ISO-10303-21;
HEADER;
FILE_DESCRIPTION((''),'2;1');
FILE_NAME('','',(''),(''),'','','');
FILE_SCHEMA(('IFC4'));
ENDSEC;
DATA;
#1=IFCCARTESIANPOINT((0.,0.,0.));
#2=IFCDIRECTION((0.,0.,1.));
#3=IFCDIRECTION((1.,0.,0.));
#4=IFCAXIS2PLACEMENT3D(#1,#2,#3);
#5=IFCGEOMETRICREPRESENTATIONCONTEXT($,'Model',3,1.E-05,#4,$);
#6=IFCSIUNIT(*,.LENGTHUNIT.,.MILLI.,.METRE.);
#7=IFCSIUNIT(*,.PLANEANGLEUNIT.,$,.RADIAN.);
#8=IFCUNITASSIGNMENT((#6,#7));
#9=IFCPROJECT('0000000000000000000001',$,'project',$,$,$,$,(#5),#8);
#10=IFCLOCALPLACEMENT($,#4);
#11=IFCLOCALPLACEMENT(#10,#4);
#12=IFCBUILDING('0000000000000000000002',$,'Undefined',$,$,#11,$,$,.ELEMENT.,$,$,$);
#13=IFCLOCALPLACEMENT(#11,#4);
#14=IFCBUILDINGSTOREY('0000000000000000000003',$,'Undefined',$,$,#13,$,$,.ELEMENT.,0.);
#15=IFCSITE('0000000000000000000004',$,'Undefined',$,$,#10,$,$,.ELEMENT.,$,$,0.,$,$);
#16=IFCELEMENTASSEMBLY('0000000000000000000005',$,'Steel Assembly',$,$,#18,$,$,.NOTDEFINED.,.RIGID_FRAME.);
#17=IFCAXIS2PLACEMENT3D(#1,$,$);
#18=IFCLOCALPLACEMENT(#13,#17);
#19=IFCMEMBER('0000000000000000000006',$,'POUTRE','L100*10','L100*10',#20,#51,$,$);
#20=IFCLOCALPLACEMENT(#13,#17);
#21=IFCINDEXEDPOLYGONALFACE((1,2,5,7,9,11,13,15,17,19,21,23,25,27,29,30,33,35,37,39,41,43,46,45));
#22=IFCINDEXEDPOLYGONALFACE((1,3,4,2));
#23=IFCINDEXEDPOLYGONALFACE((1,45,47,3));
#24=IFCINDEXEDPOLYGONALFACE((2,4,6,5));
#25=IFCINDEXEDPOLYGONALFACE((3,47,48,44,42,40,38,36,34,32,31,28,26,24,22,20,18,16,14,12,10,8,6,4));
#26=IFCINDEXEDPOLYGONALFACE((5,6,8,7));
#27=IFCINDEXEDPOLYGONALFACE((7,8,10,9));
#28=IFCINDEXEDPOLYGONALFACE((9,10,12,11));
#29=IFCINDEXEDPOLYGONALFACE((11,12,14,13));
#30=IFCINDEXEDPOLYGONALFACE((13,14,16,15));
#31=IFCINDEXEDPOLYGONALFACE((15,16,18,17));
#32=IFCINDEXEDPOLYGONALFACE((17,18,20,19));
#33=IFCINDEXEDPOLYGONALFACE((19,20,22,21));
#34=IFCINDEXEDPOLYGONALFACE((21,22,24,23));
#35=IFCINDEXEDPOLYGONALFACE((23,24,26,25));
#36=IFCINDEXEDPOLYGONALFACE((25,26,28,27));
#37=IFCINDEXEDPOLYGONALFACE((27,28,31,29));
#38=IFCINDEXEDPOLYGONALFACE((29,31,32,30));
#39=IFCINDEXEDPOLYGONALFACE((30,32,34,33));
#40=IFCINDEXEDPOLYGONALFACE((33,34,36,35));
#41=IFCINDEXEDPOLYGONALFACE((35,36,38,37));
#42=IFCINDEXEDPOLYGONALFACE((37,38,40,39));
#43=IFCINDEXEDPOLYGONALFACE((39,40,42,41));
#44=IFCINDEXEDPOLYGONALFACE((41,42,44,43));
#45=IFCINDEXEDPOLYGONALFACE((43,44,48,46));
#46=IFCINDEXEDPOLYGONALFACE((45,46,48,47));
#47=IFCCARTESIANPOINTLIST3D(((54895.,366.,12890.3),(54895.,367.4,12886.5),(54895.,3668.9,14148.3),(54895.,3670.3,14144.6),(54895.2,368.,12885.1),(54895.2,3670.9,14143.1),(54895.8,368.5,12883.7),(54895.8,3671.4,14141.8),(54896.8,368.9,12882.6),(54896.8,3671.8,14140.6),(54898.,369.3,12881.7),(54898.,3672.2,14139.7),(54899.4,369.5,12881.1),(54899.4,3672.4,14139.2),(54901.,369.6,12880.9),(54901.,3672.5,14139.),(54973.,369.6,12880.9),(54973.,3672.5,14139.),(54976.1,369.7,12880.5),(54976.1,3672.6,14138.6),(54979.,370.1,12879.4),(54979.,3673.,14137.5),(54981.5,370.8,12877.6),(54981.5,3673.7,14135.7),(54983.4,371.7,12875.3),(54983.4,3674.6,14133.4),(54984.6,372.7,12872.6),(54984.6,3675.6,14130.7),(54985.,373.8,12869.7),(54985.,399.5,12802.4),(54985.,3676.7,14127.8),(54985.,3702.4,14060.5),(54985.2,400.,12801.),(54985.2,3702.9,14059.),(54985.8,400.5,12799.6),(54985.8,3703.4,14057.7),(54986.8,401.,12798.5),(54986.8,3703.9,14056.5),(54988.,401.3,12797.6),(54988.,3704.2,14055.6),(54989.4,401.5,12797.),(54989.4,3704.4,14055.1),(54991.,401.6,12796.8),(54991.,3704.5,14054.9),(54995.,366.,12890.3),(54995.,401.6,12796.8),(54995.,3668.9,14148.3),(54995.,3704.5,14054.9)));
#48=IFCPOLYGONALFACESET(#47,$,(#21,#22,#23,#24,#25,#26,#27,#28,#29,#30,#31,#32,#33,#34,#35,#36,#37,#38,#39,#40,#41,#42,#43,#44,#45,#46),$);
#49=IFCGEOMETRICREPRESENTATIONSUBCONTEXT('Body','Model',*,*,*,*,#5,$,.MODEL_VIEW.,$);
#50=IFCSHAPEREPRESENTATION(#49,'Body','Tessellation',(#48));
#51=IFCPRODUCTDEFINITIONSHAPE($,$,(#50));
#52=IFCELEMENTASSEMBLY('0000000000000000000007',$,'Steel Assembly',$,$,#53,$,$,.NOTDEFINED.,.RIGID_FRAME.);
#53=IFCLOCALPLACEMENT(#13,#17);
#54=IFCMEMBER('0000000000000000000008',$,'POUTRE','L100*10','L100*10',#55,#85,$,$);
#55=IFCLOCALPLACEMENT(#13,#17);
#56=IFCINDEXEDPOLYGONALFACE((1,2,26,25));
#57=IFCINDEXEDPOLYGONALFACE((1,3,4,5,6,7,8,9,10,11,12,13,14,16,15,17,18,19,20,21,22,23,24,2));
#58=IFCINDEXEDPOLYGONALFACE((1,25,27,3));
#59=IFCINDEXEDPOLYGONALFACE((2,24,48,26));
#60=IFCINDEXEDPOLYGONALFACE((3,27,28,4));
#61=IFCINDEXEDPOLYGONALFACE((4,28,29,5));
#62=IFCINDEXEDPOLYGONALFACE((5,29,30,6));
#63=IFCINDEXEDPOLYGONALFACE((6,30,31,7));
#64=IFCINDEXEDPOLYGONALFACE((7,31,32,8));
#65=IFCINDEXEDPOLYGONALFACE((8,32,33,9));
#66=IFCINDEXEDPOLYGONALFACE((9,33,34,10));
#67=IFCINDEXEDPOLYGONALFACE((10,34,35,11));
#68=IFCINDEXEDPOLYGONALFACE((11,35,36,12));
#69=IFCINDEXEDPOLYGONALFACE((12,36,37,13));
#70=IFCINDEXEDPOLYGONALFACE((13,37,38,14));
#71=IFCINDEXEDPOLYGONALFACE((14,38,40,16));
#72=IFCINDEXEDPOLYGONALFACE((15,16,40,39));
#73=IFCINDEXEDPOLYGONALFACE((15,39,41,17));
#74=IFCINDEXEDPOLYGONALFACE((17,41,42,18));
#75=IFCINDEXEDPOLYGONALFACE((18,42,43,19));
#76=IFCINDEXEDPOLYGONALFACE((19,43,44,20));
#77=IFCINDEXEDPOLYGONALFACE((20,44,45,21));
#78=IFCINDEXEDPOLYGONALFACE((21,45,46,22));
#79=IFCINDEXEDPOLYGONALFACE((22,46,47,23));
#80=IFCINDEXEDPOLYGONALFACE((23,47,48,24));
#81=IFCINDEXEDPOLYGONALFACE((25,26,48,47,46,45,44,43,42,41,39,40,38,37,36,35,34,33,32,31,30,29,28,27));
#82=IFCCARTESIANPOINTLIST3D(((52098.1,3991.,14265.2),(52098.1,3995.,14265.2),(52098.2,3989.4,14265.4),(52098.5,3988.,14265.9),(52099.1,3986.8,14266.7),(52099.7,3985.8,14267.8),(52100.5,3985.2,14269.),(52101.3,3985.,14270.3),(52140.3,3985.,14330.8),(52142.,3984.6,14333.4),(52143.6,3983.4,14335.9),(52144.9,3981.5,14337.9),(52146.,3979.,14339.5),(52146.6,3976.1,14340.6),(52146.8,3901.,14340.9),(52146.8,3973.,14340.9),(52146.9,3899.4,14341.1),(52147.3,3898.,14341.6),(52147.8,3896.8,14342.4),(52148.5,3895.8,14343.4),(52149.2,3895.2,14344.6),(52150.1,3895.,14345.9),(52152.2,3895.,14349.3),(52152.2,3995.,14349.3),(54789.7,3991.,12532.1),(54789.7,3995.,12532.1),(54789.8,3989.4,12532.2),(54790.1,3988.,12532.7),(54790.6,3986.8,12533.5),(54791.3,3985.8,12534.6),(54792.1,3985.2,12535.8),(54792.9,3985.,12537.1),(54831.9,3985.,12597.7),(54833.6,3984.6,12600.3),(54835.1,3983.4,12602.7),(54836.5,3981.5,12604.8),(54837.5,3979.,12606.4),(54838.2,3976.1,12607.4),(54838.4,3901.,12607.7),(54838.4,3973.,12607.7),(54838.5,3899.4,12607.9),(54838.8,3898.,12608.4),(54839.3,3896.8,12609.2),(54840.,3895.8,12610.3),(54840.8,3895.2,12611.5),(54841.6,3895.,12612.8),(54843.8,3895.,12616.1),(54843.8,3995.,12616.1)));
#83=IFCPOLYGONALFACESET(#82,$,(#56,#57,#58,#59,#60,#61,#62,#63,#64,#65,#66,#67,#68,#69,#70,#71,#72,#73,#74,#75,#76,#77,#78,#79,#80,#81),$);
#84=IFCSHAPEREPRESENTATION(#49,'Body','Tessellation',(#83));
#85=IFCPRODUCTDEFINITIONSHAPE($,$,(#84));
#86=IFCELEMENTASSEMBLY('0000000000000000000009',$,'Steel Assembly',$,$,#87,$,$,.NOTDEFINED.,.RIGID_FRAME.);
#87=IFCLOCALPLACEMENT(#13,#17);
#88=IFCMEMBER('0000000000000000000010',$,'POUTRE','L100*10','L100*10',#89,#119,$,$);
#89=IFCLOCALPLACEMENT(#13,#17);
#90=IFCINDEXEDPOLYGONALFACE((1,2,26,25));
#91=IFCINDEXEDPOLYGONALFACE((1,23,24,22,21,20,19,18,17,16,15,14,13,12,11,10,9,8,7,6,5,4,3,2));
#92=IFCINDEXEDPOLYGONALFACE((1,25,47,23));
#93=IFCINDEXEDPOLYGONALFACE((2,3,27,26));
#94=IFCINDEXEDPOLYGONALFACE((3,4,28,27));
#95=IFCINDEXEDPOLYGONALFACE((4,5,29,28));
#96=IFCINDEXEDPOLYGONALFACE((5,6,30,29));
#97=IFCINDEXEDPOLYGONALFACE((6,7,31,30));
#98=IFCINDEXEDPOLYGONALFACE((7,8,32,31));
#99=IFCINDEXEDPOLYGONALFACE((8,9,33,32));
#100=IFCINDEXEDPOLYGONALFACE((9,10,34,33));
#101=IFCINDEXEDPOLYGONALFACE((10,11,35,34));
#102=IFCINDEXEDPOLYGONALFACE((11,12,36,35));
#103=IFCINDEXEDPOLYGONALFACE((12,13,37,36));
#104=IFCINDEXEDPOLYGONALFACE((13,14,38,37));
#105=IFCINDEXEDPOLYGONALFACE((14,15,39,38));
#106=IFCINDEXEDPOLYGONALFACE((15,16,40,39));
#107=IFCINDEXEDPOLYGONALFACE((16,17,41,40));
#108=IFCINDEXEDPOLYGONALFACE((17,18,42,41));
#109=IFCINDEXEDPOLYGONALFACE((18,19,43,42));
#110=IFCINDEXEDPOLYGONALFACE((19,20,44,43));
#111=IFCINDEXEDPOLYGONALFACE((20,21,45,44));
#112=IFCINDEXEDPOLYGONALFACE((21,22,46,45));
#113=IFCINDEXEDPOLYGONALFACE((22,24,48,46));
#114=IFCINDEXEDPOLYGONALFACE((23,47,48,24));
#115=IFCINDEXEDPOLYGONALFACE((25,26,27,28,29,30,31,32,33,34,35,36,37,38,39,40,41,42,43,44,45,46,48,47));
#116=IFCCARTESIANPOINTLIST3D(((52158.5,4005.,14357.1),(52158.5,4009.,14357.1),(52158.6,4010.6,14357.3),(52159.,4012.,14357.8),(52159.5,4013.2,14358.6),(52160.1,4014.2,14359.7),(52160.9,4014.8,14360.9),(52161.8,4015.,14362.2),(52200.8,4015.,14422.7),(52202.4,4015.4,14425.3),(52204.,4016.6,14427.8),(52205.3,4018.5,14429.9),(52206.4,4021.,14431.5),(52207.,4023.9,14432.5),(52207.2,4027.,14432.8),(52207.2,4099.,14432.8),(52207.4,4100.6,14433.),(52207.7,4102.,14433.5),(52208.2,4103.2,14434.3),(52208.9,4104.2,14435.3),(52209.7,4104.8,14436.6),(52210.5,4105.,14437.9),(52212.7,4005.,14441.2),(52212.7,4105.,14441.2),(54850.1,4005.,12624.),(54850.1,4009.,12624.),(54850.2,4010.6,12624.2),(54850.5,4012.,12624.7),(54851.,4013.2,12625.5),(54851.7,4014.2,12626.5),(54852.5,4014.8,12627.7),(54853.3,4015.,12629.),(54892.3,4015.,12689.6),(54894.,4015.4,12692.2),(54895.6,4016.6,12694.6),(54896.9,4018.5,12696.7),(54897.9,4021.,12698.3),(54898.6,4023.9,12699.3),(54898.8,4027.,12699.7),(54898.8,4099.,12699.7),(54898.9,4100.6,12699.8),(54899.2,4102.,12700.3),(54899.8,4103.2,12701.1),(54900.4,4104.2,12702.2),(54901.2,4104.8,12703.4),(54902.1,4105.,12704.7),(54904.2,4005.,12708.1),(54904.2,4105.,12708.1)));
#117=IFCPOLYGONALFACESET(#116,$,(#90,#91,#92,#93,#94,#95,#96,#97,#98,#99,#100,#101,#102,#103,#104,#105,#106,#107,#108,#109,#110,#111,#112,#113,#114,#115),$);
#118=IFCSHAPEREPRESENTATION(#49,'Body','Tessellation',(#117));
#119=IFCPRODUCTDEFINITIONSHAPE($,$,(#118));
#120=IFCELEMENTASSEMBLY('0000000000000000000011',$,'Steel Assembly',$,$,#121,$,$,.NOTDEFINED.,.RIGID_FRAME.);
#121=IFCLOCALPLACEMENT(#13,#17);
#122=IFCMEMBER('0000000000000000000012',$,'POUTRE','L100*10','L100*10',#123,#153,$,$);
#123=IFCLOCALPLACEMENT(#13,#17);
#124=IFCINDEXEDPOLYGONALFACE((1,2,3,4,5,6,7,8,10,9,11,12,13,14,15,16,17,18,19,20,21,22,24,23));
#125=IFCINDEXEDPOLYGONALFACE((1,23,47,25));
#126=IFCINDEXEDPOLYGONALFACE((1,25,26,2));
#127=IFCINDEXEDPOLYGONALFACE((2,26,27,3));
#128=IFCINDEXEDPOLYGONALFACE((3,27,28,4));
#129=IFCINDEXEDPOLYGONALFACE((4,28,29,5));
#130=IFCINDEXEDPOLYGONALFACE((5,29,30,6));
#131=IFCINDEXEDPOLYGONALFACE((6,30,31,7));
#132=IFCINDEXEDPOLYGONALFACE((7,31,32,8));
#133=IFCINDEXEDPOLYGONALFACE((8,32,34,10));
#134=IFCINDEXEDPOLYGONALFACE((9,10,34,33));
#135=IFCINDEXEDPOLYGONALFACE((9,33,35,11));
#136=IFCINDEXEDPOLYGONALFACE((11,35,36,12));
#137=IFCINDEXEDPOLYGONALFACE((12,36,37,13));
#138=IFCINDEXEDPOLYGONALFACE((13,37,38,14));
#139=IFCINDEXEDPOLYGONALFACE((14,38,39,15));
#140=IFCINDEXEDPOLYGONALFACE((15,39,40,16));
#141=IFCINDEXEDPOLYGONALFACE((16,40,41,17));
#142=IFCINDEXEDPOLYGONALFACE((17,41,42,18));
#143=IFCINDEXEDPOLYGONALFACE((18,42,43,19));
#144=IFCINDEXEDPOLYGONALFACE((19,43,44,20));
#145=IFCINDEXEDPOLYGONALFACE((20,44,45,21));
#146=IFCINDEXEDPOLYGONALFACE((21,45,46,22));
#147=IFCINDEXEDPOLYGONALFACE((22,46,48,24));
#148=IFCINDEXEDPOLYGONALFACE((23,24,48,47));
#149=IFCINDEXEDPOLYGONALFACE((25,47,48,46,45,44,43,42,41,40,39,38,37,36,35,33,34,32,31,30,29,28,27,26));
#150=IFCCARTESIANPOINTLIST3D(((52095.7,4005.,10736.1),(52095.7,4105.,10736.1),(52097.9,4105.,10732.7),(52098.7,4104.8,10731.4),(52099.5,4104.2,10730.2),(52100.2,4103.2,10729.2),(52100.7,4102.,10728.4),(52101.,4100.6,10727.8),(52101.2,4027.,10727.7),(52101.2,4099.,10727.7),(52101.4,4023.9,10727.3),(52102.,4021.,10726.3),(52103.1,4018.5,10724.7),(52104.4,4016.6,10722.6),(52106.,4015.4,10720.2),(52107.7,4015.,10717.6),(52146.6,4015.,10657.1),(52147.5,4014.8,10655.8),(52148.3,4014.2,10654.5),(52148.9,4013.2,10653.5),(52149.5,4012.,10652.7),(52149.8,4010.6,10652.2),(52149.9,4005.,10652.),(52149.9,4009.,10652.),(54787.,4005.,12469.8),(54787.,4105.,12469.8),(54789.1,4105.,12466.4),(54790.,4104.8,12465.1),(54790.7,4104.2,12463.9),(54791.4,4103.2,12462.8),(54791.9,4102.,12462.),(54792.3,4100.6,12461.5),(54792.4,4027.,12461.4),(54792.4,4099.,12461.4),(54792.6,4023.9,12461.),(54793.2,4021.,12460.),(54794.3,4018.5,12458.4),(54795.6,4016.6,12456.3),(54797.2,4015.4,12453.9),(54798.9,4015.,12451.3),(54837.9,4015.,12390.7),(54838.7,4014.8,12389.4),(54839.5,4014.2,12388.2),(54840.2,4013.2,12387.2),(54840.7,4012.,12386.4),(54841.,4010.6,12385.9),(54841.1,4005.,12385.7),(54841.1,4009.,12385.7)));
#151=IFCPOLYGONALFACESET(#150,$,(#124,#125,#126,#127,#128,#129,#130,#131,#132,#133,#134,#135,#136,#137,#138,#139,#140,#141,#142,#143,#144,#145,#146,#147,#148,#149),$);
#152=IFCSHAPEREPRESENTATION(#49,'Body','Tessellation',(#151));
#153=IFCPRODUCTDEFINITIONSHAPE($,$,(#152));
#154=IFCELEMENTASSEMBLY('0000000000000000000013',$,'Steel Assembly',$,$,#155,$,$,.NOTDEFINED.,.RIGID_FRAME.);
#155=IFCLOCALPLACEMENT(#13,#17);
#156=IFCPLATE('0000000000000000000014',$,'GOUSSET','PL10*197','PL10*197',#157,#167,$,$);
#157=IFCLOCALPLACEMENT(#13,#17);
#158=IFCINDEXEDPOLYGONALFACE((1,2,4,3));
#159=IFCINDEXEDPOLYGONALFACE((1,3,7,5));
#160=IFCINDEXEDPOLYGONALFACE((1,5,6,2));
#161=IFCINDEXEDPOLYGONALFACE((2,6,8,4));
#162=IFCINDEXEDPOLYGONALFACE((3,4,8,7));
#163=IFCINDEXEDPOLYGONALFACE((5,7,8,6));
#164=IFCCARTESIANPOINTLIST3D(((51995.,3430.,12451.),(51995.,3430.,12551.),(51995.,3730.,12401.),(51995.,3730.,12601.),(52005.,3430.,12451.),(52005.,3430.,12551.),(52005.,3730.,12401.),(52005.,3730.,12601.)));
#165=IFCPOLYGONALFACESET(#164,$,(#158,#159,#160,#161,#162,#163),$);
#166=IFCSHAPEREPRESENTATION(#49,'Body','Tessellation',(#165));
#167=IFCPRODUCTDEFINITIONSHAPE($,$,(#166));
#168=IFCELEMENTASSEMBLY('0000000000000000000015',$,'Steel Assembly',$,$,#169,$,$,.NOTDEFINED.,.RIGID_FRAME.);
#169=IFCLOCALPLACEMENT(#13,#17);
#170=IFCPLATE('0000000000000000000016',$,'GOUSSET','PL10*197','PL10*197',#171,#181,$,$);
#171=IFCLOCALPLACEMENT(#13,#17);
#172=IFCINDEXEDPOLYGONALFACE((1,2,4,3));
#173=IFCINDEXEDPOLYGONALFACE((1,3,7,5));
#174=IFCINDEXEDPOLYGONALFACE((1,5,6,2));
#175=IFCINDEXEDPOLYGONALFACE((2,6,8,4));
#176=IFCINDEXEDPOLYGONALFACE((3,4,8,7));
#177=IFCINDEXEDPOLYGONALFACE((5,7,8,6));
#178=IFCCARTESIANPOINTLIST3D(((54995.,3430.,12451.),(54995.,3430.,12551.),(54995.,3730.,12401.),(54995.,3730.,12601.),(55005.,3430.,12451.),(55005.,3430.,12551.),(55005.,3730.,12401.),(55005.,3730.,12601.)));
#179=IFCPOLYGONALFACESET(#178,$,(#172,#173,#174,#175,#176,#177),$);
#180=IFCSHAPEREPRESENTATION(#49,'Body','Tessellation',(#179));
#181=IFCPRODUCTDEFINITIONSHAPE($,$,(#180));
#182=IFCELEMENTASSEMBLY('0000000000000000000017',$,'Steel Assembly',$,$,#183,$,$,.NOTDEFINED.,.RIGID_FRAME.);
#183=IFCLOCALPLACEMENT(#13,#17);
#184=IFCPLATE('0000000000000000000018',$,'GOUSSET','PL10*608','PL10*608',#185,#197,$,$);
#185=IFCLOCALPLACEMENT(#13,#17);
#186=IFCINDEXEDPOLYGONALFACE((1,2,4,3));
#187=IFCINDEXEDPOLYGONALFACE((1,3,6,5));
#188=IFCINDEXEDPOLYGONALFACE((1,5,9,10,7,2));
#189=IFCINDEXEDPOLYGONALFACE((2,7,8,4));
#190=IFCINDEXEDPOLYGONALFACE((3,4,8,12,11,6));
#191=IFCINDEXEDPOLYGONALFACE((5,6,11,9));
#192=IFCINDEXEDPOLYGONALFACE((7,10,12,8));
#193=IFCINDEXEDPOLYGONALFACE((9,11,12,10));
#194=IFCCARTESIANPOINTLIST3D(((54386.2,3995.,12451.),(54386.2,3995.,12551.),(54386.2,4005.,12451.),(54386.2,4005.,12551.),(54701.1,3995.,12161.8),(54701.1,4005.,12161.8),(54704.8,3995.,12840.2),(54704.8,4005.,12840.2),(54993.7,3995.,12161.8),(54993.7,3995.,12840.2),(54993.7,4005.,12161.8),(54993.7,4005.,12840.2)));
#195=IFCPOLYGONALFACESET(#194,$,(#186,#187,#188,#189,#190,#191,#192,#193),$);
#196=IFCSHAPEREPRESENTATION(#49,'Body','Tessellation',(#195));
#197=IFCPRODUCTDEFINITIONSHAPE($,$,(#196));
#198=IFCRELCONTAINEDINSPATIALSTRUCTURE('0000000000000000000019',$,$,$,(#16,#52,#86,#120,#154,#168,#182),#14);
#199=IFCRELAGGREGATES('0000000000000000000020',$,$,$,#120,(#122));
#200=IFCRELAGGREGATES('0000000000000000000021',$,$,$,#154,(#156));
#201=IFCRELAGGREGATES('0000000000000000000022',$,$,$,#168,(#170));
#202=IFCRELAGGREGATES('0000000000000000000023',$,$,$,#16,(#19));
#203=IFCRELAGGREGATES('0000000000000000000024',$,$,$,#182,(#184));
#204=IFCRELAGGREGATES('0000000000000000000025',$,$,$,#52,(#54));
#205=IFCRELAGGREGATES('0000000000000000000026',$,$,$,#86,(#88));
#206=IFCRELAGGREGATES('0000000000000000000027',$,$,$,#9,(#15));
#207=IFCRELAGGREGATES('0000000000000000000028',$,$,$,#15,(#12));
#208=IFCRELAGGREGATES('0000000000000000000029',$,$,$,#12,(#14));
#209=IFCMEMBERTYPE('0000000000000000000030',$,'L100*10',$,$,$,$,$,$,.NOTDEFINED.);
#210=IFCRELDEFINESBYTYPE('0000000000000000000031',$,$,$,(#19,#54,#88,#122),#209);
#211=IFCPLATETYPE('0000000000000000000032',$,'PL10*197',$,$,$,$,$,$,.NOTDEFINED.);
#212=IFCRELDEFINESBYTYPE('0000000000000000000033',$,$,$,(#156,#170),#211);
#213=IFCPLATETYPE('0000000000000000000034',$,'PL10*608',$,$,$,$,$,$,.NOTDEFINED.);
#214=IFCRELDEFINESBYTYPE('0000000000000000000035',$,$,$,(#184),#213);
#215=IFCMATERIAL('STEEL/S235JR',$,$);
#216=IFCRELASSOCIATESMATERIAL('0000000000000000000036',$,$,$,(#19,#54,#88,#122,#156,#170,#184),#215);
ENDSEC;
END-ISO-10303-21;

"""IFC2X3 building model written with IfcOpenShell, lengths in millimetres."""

from ifc_helpers import new_model, si_unit, frame, origin_with_axes, origin_2d_with_axis, place, context, subcontext, project, spatial, polyline, l_section, outline, extrude, material, type_object, element, aggregate, save


model = new_model("IFC2X3")

# Units and contexts
model_context = context("Model", 3, precision=1e-05, world=origin_with_axes())
body_context = subcontext(model_context, "Body", "Model", "MODEL_VIEW")
ifc_project = project(units=[si_unit("LENGTHUNIT", "METRE", prefix="MILLI"), si_unit("PLANEANGLEUNIT", "RADIAN")], contexts=[model_context])

# Site, building, storey
site_placement = place(None, origin_with_axes())
site = spatial("IfcSite", under=ifc_project, at=site_placement, Name="Undefined", CompositionType="ELEMENT", RefElevation=0.0)
building_placement = place(site_placement, origin_with_axes())
building = spatial("IfcBuilding", under=site, at=building_placement, Name="Undefined", CompositionType="ELEMENT")
storey_placement = place(building_placement, origin_with_axes())
storey = spatial("IfcBuildingStorey", under=building, at=storey_placement, Name="Undefined", CompositionType="ELEMENT", Elevation=0.0)

# Shared definitions
ifc_material_1 = material(Name="STEEL/S235JR")

# Element assemblies, members
member_type = type_object("IfcMemberType", Name="L100*10", PredefinedType="NOTDEFINED")
assembly_1_placement = place(storey_placement, origin_with_axes())
assembly_1 = element("IfcElementAssembly", 1, at=assembly_1_placement, inside=storey, Name="Steel Assembly", AssemblyPlace="NOTDEFINED", PredefinedType="RIGID_FRAME")
member_1_placement = place(assembly_1_placement, frame((54945.0, 3686.7, 14101.6), z_axis=(-1.0, 0.0, 0.0), x_axis=(0.0, -0.934505, -0.355951)))
member_1 = element("IfcMember", 2, at=member_1_placement, type_object=member_type, material=ifc_material_1, Name="POUTRE", Description="L100*10", ObjectType="L100*10", context=body_context, shape_type="SweptSolid", body=[
    extrude(l_section(Depth=100.0, Width=100.0, Thickness=10.0, FilletRadius=12.0, EdgeRadius=6.0, at=origin_2d_with_axis()), frame((3534.4, 0.0, 0.0), z_axis=(-1.0, 0.0, 0.0), x_axis=(0.0, -1.0, 0.0)), (0.0, 0.0, 1.0), 3534.4),
])
assembly_2_placement = place(storey_placement, origin_with_axes())
assembly_2 = element("IfcElementAssembly", 3, at=assembly_2_placement, inside=storey, Name="Steel Assembly", AssemblyPlace="NOTDEFINED", PredefinedType="RIGID_FRAME")
member_2_placement = place(assembly_2_placement, frame((52125.1, 3945.0, 14307.3), z_axis=(0.0, -1.0, 0.0), x_axis=(0.84077, 0.0, -0.541392)))
member_2 = element("IfcMember", 4, at=member_2_placement, type_object=member_type, material=ifc_material_1, Name="POUTRE", Description="L100*10", ObjectType="L100*10", context=body_context, shape_type="SweptSolid", body=[
    extrude(l_section(Depth=100.0, Width=100.0, Thickness=10.0, FilletRadius=12.0, EdgeRadius=6.0, at=origin_2d_with_axis()), frame((3201.3, 0.0, 0.0), z_axis=(-1.0, 0.0, 0.0), x_axis=(0.0, -1.0, 0.0)), (0.0, 0.0, 1.0), 3201.3),
])
assembly_3_placement = place(storey_placement, origin_with_axes())
assembly_3 = element("IfcElementAssembly", 5, at=assembly_3_placement, inside=storey, Name="Steel Assembly", AssemblyPlace="NOTDEFINED", PredefinedType="RIGID_FRAME")
member_3_placement = place(assembly_3_placement, frame((52185.6, 4055.0, 14399.2), z_axis=(-0.541392, 0.0, -0.84077), x_axis=(0.84077, 0.0, -0.541392)))
member_3 = element("IfcMember", 6, at=member_3_placement, type_object=member_type, material=ifc_material_1, Name="POUTRE", Description="L100*10", ObjectType="L100*10", context=body_context, shape_type="SweptSolid", body=[
    extrude(l_section(Depth=100.0, Width=100.0, Thickness=10.0, FilletRadius=12.0, EdgeRadius=6.0, at=origin_2d_with_axis()), frame((3201.3, 0.0, 0.0), z_axis=(-1.0, 0.0, 0.0), x_axis=(0.0, -1.0, 0.0)), (0.0, 0.0, 1.0), 3201.3),
])
assembly_4_placement = place(storey_placement, origin_with_axes())
assembly_4 = element("IfcElementAssembly", 7, at=assembly_4_placement, inside=storey, Name="Steel Assembly", AssemblyPlace="NOTDEFINED", PredefinedType="RIGID_FRAME")
member_4_placement = place(assembly_4_placement, frame((54814.0, 4055.0, 12427.7), z_axis=(0.0, 1.0, 0.0), x_axis=(-0.840664, 0.0, -0.541558)))
member_4 = element("IfcMember", 8, at=member_4_placement, type_object=member_type, material=ifc_material_1, Name="POUTRE", Description="L100*10", ObjectType="L100*10", context=body_context, shape_type="SweptSolid", body=[
    extrude(l_section(Depth=100.0, Width=100.0, Thickness=10.0, FilletRadius=12.0, EdgeRadius=6.0, at=origin_2d_with_axis()), frame((3201.3, 0.0, 0.0), z_axis=(-1.0, 0.0, 0.0), x_axis=(0.0, -1.0, 0.0)), (0.0, 0.0, 1.0), 3201.3),
])
aggregate(assembly_4, [member_4])

# Element assemblies, plates
assembly_5_placement = place(storey_placement, origin_with_axes())
assembly_5 = element("IfcElementAssembly", 9, at=assembly_5_placement, inside=storey, Name="Steel Assembly", AssemblyPlace="NOTDEFINED", PredefinedType="RIGID_FRAME")
plate_type_1 = type_object("IfcPlateType", Name="PL10*197", PredefinedType="NOTDEFINED")
plate_1_placement = place(assembly_5_placement, frame((52000.0, 3730.0, 12601.0), z_axis=(-1.0, 0.0, 0.0), x_axis=(0.0, 0.0, -1.0)))
plate_1 = element("IfcPlate", 10, at=plate_1_placement, type_object=plate_type_1, material=ifc_material_1, Name="GOUSSET", Description="PL10*197", ObjectType="PL10*197", context=body_context, shape_type="SweptSolid", body=[
    extrude(outline(polyline([(0.0, 0.0), (200.0, 0.0), (150.0, 300.0), (50.0, 300.0), (0.0, 0.0)])), frame((0.0, 0.0, -5.0), z_axis=(0.0, 0.0, 1.0), x_axis=(1.0, 0.0, 0.0)), (0.0, 0.0, 1.0), 10.0),
])
aggregate(assembly_5, [plate_1])
assembly_6_placement = place(storey_placement, origin_with_axes())
assembly_6 = element("IfcElementAssembly", 11, at=assembly_6_placement, inside=storey, Name="Steel Assembly", AssemblyPlace="NOTDEFINED", PredefinedType="RIGID_FRAME")
plate_2_placement = place(assembly_6_placement, frame((55000.0, 3730.0, 12601.0), z_axis=(-1.0, 0.0, 0.0), x_axis=(0.0, 0.0, -1.0)))
plate_2 = element("IfcPlate", 12, at=plate_2_placement, type_object=plate_type_1, material=ifc_material_1, Name="GOUSSET", Description="PL10*197", ObjectType="PL10*197", context=body_context, shape_type="SweptSolid", body=[
    extrude(outline(polyline([(0.0, 0.0), (200.0, 0.0), (150.0, 300.0), (50.0, 300.0), (0.0, 0.0)])), frame((0.0, 0.0, -5.0), z_axis=(0.0, 0.0, 1.0), x_axis=(1.0, 0.0, 0.0)), (0.0, 0.0, 1.0), 10.0),
])
aggregate(assembly_6, [plate_2])
assembly_7_placement = place(storey_placement, origin_with_axes())
assembly_7 = element("IfcElementAssembly", 13, at=assembly_7_placement, inside=storey, Name="Steel Assembly", AssemblyPlace="NOTDEFINED", PredefinedType="RIGID_FRAME")
plate_type_2 = type_object("IfcPlateType", Name="PL10*608", PredefinedType="NOTDEFINED")
plate_3_placement = place(assembly_7_placement, frame((54993.7, 4000.0, 12840.2), z_axis=(0.0, -1.0, 0.0), x_axis=(-1.0, 0.0, 0.0)))
plate_3 = element("IfcPlate", 14, at=plate_3_placement, type_object=plate_type_2, material=ifc_material_1, Name="GOUSSET", Description="PL10*608", ObjectType="PL10*608", context=body_context, shape_type="SweptSolid", body=[
    extrude(outline(polyline([(0.0, 0.0), (288.9, 0.0), (607.5, 289.2), (607.5, 389.2), (292.6, 678.5), (0.0, 678.5), (0.0, 0.0)])), frame((0.0, 0.0, -5.0), z_axis=(0.0, 0.0, 1.0), x_axis=(1.0, 0.0, 0.0)), (0.0, 0.0, 1.0), 10.0),
])

aggregate(assembly_1, [member_1])

aggregate(assembly_7, [plate_3])

aggregate(assembly_2, [member_2])

aggregate(assembly_3, [member_3])

save(model, "model.ifc")
